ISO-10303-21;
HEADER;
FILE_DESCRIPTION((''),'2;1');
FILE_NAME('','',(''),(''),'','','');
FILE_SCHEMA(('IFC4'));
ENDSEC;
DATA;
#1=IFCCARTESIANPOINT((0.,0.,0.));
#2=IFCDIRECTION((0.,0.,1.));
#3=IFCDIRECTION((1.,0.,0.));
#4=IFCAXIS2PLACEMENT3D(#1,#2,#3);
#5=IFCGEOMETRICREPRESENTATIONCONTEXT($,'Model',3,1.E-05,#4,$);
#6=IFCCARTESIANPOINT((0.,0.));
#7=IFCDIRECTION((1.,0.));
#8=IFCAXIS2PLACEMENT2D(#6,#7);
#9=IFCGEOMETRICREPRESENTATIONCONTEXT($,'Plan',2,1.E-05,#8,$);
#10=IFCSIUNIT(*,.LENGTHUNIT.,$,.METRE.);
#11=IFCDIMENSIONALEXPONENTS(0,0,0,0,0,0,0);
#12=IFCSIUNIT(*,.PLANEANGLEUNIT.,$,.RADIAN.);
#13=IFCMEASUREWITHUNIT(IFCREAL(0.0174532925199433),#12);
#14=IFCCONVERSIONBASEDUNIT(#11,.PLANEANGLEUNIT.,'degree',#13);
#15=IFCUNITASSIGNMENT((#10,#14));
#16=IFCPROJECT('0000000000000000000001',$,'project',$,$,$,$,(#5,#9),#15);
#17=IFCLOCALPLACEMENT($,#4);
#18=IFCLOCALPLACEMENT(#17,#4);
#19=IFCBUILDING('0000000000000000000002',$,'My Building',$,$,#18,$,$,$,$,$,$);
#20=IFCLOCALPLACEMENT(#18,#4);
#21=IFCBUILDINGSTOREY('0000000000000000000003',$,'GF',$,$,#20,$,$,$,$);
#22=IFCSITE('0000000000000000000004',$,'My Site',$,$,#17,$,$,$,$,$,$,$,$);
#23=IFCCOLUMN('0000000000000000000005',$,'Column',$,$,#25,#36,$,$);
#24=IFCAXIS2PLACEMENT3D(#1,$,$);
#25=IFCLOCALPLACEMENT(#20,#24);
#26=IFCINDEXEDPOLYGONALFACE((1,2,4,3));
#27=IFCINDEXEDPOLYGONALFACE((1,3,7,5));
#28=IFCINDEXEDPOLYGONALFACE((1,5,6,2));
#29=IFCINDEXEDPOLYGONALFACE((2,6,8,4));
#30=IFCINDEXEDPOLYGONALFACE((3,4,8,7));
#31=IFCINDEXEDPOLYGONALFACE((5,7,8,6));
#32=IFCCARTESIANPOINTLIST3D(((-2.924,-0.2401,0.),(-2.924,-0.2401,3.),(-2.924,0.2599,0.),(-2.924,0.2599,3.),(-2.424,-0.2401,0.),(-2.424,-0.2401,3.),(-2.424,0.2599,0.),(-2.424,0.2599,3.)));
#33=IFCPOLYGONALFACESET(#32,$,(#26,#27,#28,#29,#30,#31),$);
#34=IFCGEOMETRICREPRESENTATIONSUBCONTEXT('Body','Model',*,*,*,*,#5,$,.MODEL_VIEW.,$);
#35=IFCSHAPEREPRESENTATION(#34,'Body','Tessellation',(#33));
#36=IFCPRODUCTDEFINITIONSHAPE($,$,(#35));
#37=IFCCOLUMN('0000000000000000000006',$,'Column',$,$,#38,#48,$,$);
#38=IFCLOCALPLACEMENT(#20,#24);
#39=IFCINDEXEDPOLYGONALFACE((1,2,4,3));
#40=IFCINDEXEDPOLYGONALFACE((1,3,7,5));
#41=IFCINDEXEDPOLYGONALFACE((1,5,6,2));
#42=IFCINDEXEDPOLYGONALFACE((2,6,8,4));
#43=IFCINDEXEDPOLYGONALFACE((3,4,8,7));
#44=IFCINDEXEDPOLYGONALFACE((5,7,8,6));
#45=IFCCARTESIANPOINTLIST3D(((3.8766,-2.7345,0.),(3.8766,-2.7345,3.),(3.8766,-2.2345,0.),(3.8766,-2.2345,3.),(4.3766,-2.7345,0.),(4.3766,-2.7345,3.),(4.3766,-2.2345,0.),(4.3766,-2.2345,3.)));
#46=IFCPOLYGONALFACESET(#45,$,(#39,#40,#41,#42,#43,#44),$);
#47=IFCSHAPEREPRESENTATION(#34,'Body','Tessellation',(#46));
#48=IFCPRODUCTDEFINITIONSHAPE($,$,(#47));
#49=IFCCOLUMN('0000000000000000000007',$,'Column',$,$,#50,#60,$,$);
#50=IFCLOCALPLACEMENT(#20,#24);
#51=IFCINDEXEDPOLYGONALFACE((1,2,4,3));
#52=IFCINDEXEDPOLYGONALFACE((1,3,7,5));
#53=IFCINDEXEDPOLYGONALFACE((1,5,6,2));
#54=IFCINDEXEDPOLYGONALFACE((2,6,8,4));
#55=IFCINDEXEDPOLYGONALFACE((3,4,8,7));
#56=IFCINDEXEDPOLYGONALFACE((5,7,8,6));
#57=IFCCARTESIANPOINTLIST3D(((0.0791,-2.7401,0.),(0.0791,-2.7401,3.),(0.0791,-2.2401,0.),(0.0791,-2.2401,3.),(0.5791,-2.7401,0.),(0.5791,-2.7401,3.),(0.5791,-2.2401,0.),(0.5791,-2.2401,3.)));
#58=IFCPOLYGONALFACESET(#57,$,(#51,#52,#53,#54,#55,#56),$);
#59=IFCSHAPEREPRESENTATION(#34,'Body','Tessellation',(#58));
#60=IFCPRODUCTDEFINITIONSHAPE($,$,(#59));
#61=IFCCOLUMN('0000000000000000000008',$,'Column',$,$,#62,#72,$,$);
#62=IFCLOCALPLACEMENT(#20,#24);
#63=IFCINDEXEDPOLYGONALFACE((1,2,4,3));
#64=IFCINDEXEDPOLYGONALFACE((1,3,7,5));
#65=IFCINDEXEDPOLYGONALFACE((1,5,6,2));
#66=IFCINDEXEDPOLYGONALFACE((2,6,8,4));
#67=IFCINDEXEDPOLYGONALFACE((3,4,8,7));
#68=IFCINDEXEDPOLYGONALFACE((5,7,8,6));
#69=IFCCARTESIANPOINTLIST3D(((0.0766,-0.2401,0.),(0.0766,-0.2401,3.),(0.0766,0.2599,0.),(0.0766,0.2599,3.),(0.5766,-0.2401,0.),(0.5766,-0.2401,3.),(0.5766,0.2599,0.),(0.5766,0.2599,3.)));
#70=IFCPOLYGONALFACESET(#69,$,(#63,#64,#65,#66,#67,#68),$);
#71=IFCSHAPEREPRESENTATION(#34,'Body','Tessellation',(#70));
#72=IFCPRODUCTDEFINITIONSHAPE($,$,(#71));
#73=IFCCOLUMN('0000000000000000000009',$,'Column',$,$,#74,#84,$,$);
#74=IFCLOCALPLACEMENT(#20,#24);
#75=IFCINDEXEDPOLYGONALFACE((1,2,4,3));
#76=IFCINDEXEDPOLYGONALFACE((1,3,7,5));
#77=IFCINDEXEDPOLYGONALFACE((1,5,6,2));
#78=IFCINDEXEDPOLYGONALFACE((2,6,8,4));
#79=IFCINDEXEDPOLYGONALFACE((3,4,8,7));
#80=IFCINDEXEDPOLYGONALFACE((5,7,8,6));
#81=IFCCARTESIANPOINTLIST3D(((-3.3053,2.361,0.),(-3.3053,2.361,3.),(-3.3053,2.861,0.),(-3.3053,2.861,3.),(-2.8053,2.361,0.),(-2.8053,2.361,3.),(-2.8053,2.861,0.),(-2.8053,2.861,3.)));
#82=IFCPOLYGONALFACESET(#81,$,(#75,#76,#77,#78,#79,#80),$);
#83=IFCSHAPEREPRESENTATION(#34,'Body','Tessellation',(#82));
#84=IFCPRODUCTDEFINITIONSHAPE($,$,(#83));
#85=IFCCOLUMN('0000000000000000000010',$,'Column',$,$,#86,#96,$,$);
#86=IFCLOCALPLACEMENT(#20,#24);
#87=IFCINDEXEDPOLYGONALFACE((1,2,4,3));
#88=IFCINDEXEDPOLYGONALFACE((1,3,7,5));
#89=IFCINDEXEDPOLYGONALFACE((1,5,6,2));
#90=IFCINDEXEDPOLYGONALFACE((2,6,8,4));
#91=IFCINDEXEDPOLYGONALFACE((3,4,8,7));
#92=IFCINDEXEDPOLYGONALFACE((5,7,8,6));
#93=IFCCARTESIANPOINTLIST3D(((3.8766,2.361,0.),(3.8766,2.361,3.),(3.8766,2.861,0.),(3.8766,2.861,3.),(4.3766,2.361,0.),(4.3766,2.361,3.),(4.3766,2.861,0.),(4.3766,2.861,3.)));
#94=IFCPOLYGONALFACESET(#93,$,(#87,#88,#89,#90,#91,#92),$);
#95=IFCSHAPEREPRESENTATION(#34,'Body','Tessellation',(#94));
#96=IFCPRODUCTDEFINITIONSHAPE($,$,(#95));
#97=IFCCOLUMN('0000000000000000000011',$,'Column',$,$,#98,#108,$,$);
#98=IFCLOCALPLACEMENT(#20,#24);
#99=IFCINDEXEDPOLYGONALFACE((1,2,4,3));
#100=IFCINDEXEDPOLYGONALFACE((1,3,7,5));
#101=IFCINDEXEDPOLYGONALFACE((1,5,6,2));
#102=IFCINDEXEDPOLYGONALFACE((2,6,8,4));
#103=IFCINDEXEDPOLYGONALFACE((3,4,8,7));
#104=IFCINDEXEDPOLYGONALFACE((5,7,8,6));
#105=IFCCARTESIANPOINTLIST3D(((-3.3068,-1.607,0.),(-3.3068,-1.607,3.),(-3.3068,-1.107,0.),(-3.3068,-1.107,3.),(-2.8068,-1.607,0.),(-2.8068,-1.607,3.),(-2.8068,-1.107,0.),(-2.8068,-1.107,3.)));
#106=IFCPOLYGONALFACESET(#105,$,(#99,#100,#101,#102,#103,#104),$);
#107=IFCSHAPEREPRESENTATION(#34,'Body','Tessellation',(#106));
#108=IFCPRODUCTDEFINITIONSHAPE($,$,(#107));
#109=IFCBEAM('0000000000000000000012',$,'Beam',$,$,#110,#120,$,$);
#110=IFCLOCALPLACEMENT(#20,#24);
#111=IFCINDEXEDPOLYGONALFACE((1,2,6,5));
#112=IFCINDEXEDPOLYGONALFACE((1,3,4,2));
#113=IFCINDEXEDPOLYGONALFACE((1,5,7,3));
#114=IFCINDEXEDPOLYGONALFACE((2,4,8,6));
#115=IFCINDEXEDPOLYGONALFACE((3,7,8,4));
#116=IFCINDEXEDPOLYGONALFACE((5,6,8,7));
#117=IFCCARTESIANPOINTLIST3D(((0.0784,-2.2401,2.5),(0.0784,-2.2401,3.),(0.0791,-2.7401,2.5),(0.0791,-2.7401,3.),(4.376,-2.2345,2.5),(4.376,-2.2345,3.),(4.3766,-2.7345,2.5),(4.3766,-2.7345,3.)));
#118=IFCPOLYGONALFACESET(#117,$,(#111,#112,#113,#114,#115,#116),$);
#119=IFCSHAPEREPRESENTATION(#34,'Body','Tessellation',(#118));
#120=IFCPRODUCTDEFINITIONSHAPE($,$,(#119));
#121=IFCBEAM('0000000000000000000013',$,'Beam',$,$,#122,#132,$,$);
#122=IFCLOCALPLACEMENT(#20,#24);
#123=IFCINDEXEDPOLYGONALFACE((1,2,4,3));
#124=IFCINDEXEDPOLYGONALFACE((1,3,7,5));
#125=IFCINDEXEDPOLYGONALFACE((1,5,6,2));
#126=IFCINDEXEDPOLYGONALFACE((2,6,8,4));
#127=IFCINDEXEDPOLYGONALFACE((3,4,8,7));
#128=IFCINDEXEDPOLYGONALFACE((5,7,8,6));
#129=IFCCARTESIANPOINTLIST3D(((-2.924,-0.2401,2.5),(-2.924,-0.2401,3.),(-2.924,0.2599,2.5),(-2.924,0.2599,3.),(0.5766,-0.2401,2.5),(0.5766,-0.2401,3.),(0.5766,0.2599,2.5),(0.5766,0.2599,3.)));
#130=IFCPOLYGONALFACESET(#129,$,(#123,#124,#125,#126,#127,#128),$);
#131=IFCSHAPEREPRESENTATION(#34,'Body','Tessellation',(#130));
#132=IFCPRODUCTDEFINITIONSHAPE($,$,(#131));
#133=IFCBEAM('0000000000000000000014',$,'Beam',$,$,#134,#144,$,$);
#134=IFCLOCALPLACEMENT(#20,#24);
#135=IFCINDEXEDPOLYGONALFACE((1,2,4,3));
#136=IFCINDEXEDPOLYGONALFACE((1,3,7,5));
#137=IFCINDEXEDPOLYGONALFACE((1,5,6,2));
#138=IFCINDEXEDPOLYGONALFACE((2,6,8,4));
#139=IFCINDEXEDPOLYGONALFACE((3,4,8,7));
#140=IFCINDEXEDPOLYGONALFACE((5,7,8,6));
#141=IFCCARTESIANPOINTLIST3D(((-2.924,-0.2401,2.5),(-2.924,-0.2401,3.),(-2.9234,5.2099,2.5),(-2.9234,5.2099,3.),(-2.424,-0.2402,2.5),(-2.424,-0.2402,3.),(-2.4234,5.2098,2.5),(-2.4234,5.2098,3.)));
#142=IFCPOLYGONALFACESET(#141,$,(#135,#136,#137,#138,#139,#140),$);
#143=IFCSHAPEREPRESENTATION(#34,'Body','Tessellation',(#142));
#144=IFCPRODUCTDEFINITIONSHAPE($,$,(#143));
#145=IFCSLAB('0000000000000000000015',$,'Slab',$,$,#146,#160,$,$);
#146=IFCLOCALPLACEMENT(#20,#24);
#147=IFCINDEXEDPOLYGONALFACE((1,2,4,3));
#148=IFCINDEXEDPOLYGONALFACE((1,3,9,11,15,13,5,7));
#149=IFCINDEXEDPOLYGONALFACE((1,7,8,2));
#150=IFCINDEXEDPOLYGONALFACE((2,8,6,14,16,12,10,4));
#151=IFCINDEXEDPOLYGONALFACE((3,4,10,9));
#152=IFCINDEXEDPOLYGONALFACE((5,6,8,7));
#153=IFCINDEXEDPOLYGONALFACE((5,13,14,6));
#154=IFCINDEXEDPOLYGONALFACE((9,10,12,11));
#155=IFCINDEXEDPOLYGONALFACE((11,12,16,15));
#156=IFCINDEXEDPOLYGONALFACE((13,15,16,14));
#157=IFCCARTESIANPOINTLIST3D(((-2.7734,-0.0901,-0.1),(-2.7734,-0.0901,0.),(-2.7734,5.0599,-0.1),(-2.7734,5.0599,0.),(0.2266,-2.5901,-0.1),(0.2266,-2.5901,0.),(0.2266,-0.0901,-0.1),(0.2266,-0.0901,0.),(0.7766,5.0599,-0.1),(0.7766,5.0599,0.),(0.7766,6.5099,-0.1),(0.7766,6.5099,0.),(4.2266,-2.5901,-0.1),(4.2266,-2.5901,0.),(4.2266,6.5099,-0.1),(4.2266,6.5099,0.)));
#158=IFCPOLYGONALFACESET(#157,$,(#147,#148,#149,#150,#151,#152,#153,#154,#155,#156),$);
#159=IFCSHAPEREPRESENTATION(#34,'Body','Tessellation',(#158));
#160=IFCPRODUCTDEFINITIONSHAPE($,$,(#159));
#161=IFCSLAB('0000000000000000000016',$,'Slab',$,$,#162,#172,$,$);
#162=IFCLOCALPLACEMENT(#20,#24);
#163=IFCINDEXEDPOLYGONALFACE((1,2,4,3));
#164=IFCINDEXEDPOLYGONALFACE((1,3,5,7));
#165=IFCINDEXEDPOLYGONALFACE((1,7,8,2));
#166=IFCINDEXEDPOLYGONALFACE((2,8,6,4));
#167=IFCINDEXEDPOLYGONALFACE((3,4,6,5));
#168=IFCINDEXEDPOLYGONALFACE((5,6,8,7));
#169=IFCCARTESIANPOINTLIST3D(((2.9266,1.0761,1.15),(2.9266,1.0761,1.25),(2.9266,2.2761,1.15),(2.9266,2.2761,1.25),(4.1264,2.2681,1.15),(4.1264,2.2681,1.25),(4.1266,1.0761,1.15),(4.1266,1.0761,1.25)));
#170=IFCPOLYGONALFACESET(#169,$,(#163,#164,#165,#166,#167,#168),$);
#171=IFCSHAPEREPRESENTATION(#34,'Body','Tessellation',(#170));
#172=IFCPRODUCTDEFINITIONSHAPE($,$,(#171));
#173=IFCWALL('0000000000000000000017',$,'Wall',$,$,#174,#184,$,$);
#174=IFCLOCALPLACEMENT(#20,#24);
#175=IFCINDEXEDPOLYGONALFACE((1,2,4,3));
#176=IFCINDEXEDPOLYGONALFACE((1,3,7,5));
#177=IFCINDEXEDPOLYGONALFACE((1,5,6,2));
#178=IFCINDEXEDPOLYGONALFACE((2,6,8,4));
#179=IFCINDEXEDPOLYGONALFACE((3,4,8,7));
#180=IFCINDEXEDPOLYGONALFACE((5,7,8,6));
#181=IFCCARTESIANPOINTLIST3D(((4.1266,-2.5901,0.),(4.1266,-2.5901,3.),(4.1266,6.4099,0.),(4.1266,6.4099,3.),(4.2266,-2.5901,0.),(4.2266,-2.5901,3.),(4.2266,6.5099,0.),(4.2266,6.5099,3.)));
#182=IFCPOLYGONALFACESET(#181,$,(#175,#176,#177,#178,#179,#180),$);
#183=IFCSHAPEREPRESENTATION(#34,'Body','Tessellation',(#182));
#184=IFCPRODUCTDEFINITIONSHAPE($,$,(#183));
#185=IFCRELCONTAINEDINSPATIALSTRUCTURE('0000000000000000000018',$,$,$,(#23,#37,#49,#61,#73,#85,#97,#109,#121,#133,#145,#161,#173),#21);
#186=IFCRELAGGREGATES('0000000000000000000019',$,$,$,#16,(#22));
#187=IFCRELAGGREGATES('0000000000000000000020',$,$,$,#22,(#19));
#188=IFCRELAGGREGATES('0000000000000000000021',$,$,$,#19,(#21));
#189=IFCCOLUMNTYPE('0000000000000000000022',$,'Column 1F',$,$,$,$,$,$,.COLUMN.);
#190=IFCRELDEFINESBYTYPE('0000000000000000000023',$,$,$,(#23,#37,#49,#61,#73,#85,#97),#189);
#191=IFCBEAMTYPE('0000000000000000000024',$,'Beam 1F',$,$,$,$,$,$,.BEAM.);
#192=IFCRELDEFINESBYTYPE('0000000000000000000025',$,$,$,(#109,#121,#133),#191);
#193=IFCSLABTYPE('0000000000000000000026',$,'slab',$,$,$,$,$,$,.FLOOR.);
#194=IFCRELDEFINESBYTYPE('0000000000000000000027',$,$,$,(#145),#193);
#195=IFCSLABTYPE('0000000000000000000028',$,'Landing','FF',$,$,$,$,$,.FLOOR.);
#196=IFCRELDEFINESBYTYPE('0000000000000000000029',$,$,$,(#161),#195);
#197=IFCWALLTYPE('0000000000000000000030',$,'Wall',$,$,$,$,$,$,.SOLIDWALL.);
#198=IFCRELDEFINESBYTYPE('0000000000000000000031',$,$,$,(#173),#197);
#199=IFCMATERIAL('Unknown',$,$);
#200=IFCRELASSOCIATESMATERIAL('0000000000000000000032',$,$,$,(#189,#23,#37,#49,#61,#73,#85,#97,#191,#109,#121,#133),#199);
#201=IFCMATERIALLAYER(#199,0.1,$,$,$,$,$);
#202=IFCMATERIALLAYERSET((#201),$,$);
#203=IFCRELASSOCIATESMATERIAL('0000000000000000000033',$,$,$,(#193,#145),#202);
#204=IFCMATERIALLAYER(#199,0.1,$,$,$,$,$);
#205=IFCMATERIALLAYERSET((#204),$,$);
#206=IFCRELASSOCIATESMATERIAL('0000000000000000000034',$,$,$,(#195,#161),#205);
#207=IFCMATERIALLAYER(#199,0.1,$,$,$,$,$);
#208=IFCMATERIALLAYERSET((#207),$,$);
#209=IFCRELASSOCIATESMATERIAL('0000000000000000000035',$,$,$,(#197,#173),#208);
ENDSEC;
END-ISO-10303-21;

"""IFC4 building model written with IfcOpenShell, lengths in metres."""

from ifc_helpers import new_model, entity, si_unit, converted_unit, frame, origin_with_axes, origin_2d_with_axis, place, context, subcontext, project, spatial, line, indexed_curve, rectangle, outline, extrude, material, layer, layer_set, layer_usage, material_profile, profile_set, profile_usage, type_object, element, save


model = new_model("IFC4")

# Units and contexts
model_context = context("Model", 3, precision=1e-05, world=origin_with_axes())
plan_context = context("Plan", 2, precision=1e-05, world=origin_2d_with_axis())
body_context_1 = subcontext(model_context, "Body", "Model", "MODEL_VIEW")
ifc_project = project(units=[si_unit("LENGTHUNIT", "METRE"), converted_unit("PLANEANGLEUNIT", "degree", entity("IfcReal", 0.0174532925199433), si_unit("PLANEANGLEUNIT", "RADIAN"), dimensions=[0, 0, 0, 0, 0, 0, 0])], contexts=[model_context, plan_context])

# Site, building, storey
site_placement = place(None, origin_with_axes())
site = spatial("IfcSite", under=ifc_project, at=site_placement, Name="My Site")
building_placement = place(site_placement, origin_with_axes())
building = spatial("IfcBuilding", under=site, at=building_placement, Name="My Building")
storey_placement = place(building_placement, origin_with_axes())
storey = spatial("IfcBuildingStorey", under=building, at=storey_placement, Name="GF")

# Columns
ifc_material_1 = material(Name="Unknown")
ifc_material_profile_1 = material_profile(ifc_material_1, rectangle(XDim=0.5, YDim=0.5))
ifc_profile_set_1 = profile_set([ifc_material_profile_1])
ifc_profile_usage_1 = profile_usage(ifc_profile_set_1, cardinal=5)
column_type = type_object("IfcColumnType", Name="Column 1F", PredefinedType="COLUMN", material=ifc_profile_set_1)
column_1_placement = place(storey_placement, frame((-2.674, 0.0099, 0.0), z_axis=(0.0, 0.0, 1.0), x_axis=(1.0, 0.0, 0.0)))
element("IfcColumn", 1, at=column_1_placement, inside=storey, type_object=column_type, material=ifc_profile_usage_1, Name="Column", context=body_context_1, shape_type="SweptSolid", body=[
    extrude(rectangle(XDim=0.5, YDim=0.5), origin_with_axes(), (0.0, 0.0, 1.0), 3.0),
])
ifc_profile_usage_2 = profile_usage(ifc_profile_set_1, cardinal=5)
column_2_placement = place(storey_placement, frame((4.1266, -2.4845, 0.0), z_axis=(0.0, 0.0, 1.0), x_axis=(1.0, 0.0, 0.0)))
element("IfcColumn", 2, at=column_2_placement, inside=storey, type_object=column_type, material=ifc_profile_usage_2, Name="Column", context=body_context_1, shape_type="SweptSolid", body=[
    extrude(rectangle(XDim=0.5, YDim=0.5), origin_with_axes(), (0.0, 0.0, 1.0), 3.0),
])
ifc_profile_usage_3 = profile_usage(ifc_profile_set_1, cardinal=5)
column_3_placement = place(storey_placement, frame((0.3291, -2.4901, 0.0), z_axis=(0.0, 0.0, 1.0), x_axis=(1.0, 0.0, 0.0)))
element("IfcColumn", 3, at=column_3_placement, inside=storey, type_object=column_type, material=ifc_profile_usage_3, Name="Column", context=body_context_1, shape_type="SweptSolid", body=[
    extrude(rectangle(XDim=0.5, YDim=0.5), origin_with_axes(), (0.0, 0.0, 1.0), 3.0),
])
ifc_profile_usage_4 = profile_usage(ifc_profile_set_1, cardinal=5)
column_4_placement = place(storey_placement, frame((0.3266, 0.0099, 0.0), z_axis=(0.0, 0.0, 1.0), x_axis=(1.0, 0.0, 0.0)))
element("IfcColumn", 4, at=column_4_placement, inside=storey, type_object=column_type, material=ifc_profile_usage_4, Name="Column", context=body_context_1, shape_type="SweptSolid", body=[
    extrude(rectangle(XDim=0.5, YDim=0.5), origin_with_axes(), (0.0, 0.0, 1.0), 3.0),
])
ifc_profile_usage_5 = profile_usage(ifc_profile_set_1, cardinal=5)
column_5_placement = place(storey_placement, frame((-3.0553, 2.611, 0.0), z_axis=(0.0, 0.0, 1.0), x_axis=(1.0, 0.0, 0.0)))
element("IfcColumn", 5, at=column_5_placement, inside=storey, type_object=column_type, material=ifc_profile_usage_5, Name="Column", context=body_context_1, shape_type="SweptSolid", body=[
    extrude(rectangle(XDim=0.5, YDim=0.5), origin_with_axes(), (0.0, 0.0, 1.0), 3.0),
])
ifc_profile_usage_6 = profile_usage(ifc_profile_set_1, cardinal=5)
column_6_placement = place(storey_placement, frame((4.1266, 2.611, 0.0), z_axis=(0.0, 0.0, 1.0), x_axis=(1.0, 0.0, 0.0)))
element("IfcColumn", 6, at=column_6_placement, inside=storey, type_object=column_type, material=ifc_profile_usage_6, Name="Column", context=body_context_1, shape_type="SweptSolid", body=[
    extrude(rectangle(XDim=0.5, YDim=0.5), origin_with_axes(), (0.0, 0.0, 1.0), 3.0),
])
ifc_profile_usage_7 = profile_usage(ifc_profile_set_1, cardinal=3)
column_7_placement = place(storey_placement, frame((-3.3068, -1.607, 0.0), z_axis=(0.0, 0.0, 1.0), x_axis=(1.0, 0.0, 0.0)))
element("IfcColumn", 7, at=column_7_placement, inside=storey, type_object=column_type, material=ifc_profile_usage_7, Name="Column", context=body_context_1, shape_type="SweptSolid", body=[
    extrude(rectangle(XDim=0.5, YDim=0.5), frame((0.25, 0.25, 0.0), z_axis=(0.0, 0.0, 1.0), x_axis=(1.0, 0.0, 0.0)), (0.0, 0.0, 1.0), 3.0),
])

# Beams
ifc_material_profile_2 = material_profile(ifc_material_1, rectangle(XDim=0.5, YDim=0.5))
ifc_profile_set_2 = profile_set([ifc_material_profile_2])
ifc_profile_usage_8 = profile_usage(ifc_profile_set_2, cardinal=7)
beam_type = type_object("IfcBeamType", Name="Beam 1F", PredefinedType="BEAM", material=ifc_profile_set_2)
beam_1_placement = place(storey_placement, frame((4.3766, -2.7345, 3.0), z_axis=(-0.999999, -0.001305, 0.0), x_axis=(0.001305, -0.999999, 0.0)))
element("IfcBeam", 8, at=beam_1_placement, inside=storey, type_object=beam_type, material=ifc_profile_usage_8, Name="Beam", context=body_context_1, shape_type="SweptSolid", body=[
    extrude(rectangle(XDim=0.5, YDim=0.5), frame((-0.25, -0.25, 0.0), z_axis=(0.0, 0.0, 1.0), x_axis=(1.0, 0.0, 0.0)), (0.0, 0.0, 1.0), 4.2975),
])
ifc_profile_usage_9 = profile_usage(ifc_profile_set_2, cardinal=7)
beam_2_placement = place(storey_placement, frame((0.5766, -0.2401, 3.0), z_axis=(-1.0, -0.000008, 0.0), x_axis=(0.000008, -1.0, 0.0)))
element("IfcBeam", 9, at=beam_2_placement, inside=storey, type_object=beam_type, material=ifc_profile_usage_9, Name="Beam", context=body_context_1, shape_type="SweptSolid", body=[
    extrude(rectangle(XDim=0.5, YDim=0.5), frame((-0.25, -0.25, 0.0), z_axis=(0.0, 0.0, 1.0), x_axis=(1.0, 0.0, 0.0)), (0.0, 0.0, 1.0), 3.5006),
])
ifc_profile_usage_10 = profile_usage(ifc_profile_set_2, cardinal=7)
beam_3_placement = place(storey_placement, frame((-2.924, -0.2401, 3.0), z_axis=(0.000102, 1.0, 0.0), x_axis=(-1.0, 0.000102, 0.0)))
element("IfcBeam", 10, at=beam_3_placement, inside=storey, type_object=beam_type, material=ifc_profile_usage_10, Name="Beam", context=body_context_1, shape_type="SweptSolid", body=[
    extrude(rectangle(XDim=0.5, YDim=0.5), frame((-0.25, -0.25, 0.0), z_axis=(0.0, 0.0, 1.0), x_axis=(1.0, 0.0, 0.0)), (0.0, 0.0, 1.0), 5.45),
])

# Slabs
ifc_layer_1 = layer(ifc_material_1, 0.1)
ifc_layer_set_1 = layer_set([ifc_layer_1])
ifc_layer_usage_1 = layer_usage(ifc_layer_set_1, "AXIS3", "POSITIVE", -0.1)
slab_type_1 = type_object("IfcSlabType", Name="slab", PredefinedType="FLOOR", material=ifc_layer_set_1)
slab_1_placement = place(storey_placement, frame((4.2266, -2.5901, 0.0), z_axis=(0.0, 0.0, 1.0), x_axis=(1.0, 0.0, 0.0)))
element("IfcSlab", 11, at=slab_1_placement, inside=storey, type_object=slab_type_1, material=ifc_layer_usage_1, Name="Slab", context=body_context_1, shape_type="SweptSolid", body=[
    extrude(outline(indexed_curve([(0.0, 0.0), (0.0, 9.1), (-3.45, 9.1), (-3.45, 7.65), (-7.0, 7.65), (-7.0, 2.5), (-4.0, 2.5), (-4.0, 0.0), (0.0, 0.0)])), frame((0.0, 0.0, -0.1), z_axis=(0.0, 0.0, 1.0), x_axis=(1.0, 0.0, 0.0)), (0.0, 0.0, 1.0), 0.1),
])
ifc_layer_2 = layer(ifc_material_1, 0.1)
ifc_layer_set_2 = layer_set([ifc_layer_2])
ifc_layer_usage_2 = layer_usage(ifc_layer_set_2, "AXIS3", "POSITIVE", -0.1)
slab_type_2 = type_object("IfcSlabType", Name="Landing", Description="FF", PredefinedType="FLOOR", material=ifc_layer_set_2)
slab_2_placement = place(storey_placement, frame((2.9266, 2.2761, 1.25), z_axis=(0.0, 0.0, 1.0), x_axis=(1.0, 0.0, 0.0)))
element("IfcSlab", 12, at=slab_2_placement, inside=storey, type_object=slab_type_2, material=ifc_layer_usage_2, Name="Slab", context=body_context_1, shape_type="SweptSolid", body=[
    extrude(outline(indexed_curve([(0.0, 0.0), (0.0, -1.2), (1.2, -1.2), (1.1997, -0.0079), (0.0, 0.0)])), frame((0.0, 0.0, -0.1), z_axis=(0.0, 0.0, 1.0), x_axis=(1.0, 0.0, 0.0)), (0.0, 0.0, 1.0), 0.1),
])

# Shared definitions
ifc_layer_3 = layer(ifc_material_1, 0.1)
ifc_layer_set_3 = layer_set([ifc_layer_3])
wall_type = type_object("IfcWallType", Name="Wall", PredefinedType="SOLIDWALL", material=ifc_layer_set_3)

# Wall
ifc_layer_usage_3 = layer_usage(ifc_layer_set_3, "AXIS2", "POSITIVE", 0.0)
wall_1_placement = place(storey_placement, frame((4.2266, -2.5901, 0.0), z_axis=(0.0, 0.0, 1.0), x_axis=(0.0, 1.0, 0.0)))
element("IfcWall", 13, at=wall_1_placement, inside=storey, type_object=wall_type, material=ifc_layer_usage_3, Name="Wall", context=body_context_1, shape_type="SweptSolid", body=[
    extrude(outline(indexed_curve([(0.0, 0.0), (0.0, 0.1), (9.0, 0.1), (9.1, 0.0)], segments=[line(1, 2, 3, 4, 1)])), origin_with_axes(), (0.0, 0.0, 1.0), 3.0),
])

save(model, "model.ifc")
